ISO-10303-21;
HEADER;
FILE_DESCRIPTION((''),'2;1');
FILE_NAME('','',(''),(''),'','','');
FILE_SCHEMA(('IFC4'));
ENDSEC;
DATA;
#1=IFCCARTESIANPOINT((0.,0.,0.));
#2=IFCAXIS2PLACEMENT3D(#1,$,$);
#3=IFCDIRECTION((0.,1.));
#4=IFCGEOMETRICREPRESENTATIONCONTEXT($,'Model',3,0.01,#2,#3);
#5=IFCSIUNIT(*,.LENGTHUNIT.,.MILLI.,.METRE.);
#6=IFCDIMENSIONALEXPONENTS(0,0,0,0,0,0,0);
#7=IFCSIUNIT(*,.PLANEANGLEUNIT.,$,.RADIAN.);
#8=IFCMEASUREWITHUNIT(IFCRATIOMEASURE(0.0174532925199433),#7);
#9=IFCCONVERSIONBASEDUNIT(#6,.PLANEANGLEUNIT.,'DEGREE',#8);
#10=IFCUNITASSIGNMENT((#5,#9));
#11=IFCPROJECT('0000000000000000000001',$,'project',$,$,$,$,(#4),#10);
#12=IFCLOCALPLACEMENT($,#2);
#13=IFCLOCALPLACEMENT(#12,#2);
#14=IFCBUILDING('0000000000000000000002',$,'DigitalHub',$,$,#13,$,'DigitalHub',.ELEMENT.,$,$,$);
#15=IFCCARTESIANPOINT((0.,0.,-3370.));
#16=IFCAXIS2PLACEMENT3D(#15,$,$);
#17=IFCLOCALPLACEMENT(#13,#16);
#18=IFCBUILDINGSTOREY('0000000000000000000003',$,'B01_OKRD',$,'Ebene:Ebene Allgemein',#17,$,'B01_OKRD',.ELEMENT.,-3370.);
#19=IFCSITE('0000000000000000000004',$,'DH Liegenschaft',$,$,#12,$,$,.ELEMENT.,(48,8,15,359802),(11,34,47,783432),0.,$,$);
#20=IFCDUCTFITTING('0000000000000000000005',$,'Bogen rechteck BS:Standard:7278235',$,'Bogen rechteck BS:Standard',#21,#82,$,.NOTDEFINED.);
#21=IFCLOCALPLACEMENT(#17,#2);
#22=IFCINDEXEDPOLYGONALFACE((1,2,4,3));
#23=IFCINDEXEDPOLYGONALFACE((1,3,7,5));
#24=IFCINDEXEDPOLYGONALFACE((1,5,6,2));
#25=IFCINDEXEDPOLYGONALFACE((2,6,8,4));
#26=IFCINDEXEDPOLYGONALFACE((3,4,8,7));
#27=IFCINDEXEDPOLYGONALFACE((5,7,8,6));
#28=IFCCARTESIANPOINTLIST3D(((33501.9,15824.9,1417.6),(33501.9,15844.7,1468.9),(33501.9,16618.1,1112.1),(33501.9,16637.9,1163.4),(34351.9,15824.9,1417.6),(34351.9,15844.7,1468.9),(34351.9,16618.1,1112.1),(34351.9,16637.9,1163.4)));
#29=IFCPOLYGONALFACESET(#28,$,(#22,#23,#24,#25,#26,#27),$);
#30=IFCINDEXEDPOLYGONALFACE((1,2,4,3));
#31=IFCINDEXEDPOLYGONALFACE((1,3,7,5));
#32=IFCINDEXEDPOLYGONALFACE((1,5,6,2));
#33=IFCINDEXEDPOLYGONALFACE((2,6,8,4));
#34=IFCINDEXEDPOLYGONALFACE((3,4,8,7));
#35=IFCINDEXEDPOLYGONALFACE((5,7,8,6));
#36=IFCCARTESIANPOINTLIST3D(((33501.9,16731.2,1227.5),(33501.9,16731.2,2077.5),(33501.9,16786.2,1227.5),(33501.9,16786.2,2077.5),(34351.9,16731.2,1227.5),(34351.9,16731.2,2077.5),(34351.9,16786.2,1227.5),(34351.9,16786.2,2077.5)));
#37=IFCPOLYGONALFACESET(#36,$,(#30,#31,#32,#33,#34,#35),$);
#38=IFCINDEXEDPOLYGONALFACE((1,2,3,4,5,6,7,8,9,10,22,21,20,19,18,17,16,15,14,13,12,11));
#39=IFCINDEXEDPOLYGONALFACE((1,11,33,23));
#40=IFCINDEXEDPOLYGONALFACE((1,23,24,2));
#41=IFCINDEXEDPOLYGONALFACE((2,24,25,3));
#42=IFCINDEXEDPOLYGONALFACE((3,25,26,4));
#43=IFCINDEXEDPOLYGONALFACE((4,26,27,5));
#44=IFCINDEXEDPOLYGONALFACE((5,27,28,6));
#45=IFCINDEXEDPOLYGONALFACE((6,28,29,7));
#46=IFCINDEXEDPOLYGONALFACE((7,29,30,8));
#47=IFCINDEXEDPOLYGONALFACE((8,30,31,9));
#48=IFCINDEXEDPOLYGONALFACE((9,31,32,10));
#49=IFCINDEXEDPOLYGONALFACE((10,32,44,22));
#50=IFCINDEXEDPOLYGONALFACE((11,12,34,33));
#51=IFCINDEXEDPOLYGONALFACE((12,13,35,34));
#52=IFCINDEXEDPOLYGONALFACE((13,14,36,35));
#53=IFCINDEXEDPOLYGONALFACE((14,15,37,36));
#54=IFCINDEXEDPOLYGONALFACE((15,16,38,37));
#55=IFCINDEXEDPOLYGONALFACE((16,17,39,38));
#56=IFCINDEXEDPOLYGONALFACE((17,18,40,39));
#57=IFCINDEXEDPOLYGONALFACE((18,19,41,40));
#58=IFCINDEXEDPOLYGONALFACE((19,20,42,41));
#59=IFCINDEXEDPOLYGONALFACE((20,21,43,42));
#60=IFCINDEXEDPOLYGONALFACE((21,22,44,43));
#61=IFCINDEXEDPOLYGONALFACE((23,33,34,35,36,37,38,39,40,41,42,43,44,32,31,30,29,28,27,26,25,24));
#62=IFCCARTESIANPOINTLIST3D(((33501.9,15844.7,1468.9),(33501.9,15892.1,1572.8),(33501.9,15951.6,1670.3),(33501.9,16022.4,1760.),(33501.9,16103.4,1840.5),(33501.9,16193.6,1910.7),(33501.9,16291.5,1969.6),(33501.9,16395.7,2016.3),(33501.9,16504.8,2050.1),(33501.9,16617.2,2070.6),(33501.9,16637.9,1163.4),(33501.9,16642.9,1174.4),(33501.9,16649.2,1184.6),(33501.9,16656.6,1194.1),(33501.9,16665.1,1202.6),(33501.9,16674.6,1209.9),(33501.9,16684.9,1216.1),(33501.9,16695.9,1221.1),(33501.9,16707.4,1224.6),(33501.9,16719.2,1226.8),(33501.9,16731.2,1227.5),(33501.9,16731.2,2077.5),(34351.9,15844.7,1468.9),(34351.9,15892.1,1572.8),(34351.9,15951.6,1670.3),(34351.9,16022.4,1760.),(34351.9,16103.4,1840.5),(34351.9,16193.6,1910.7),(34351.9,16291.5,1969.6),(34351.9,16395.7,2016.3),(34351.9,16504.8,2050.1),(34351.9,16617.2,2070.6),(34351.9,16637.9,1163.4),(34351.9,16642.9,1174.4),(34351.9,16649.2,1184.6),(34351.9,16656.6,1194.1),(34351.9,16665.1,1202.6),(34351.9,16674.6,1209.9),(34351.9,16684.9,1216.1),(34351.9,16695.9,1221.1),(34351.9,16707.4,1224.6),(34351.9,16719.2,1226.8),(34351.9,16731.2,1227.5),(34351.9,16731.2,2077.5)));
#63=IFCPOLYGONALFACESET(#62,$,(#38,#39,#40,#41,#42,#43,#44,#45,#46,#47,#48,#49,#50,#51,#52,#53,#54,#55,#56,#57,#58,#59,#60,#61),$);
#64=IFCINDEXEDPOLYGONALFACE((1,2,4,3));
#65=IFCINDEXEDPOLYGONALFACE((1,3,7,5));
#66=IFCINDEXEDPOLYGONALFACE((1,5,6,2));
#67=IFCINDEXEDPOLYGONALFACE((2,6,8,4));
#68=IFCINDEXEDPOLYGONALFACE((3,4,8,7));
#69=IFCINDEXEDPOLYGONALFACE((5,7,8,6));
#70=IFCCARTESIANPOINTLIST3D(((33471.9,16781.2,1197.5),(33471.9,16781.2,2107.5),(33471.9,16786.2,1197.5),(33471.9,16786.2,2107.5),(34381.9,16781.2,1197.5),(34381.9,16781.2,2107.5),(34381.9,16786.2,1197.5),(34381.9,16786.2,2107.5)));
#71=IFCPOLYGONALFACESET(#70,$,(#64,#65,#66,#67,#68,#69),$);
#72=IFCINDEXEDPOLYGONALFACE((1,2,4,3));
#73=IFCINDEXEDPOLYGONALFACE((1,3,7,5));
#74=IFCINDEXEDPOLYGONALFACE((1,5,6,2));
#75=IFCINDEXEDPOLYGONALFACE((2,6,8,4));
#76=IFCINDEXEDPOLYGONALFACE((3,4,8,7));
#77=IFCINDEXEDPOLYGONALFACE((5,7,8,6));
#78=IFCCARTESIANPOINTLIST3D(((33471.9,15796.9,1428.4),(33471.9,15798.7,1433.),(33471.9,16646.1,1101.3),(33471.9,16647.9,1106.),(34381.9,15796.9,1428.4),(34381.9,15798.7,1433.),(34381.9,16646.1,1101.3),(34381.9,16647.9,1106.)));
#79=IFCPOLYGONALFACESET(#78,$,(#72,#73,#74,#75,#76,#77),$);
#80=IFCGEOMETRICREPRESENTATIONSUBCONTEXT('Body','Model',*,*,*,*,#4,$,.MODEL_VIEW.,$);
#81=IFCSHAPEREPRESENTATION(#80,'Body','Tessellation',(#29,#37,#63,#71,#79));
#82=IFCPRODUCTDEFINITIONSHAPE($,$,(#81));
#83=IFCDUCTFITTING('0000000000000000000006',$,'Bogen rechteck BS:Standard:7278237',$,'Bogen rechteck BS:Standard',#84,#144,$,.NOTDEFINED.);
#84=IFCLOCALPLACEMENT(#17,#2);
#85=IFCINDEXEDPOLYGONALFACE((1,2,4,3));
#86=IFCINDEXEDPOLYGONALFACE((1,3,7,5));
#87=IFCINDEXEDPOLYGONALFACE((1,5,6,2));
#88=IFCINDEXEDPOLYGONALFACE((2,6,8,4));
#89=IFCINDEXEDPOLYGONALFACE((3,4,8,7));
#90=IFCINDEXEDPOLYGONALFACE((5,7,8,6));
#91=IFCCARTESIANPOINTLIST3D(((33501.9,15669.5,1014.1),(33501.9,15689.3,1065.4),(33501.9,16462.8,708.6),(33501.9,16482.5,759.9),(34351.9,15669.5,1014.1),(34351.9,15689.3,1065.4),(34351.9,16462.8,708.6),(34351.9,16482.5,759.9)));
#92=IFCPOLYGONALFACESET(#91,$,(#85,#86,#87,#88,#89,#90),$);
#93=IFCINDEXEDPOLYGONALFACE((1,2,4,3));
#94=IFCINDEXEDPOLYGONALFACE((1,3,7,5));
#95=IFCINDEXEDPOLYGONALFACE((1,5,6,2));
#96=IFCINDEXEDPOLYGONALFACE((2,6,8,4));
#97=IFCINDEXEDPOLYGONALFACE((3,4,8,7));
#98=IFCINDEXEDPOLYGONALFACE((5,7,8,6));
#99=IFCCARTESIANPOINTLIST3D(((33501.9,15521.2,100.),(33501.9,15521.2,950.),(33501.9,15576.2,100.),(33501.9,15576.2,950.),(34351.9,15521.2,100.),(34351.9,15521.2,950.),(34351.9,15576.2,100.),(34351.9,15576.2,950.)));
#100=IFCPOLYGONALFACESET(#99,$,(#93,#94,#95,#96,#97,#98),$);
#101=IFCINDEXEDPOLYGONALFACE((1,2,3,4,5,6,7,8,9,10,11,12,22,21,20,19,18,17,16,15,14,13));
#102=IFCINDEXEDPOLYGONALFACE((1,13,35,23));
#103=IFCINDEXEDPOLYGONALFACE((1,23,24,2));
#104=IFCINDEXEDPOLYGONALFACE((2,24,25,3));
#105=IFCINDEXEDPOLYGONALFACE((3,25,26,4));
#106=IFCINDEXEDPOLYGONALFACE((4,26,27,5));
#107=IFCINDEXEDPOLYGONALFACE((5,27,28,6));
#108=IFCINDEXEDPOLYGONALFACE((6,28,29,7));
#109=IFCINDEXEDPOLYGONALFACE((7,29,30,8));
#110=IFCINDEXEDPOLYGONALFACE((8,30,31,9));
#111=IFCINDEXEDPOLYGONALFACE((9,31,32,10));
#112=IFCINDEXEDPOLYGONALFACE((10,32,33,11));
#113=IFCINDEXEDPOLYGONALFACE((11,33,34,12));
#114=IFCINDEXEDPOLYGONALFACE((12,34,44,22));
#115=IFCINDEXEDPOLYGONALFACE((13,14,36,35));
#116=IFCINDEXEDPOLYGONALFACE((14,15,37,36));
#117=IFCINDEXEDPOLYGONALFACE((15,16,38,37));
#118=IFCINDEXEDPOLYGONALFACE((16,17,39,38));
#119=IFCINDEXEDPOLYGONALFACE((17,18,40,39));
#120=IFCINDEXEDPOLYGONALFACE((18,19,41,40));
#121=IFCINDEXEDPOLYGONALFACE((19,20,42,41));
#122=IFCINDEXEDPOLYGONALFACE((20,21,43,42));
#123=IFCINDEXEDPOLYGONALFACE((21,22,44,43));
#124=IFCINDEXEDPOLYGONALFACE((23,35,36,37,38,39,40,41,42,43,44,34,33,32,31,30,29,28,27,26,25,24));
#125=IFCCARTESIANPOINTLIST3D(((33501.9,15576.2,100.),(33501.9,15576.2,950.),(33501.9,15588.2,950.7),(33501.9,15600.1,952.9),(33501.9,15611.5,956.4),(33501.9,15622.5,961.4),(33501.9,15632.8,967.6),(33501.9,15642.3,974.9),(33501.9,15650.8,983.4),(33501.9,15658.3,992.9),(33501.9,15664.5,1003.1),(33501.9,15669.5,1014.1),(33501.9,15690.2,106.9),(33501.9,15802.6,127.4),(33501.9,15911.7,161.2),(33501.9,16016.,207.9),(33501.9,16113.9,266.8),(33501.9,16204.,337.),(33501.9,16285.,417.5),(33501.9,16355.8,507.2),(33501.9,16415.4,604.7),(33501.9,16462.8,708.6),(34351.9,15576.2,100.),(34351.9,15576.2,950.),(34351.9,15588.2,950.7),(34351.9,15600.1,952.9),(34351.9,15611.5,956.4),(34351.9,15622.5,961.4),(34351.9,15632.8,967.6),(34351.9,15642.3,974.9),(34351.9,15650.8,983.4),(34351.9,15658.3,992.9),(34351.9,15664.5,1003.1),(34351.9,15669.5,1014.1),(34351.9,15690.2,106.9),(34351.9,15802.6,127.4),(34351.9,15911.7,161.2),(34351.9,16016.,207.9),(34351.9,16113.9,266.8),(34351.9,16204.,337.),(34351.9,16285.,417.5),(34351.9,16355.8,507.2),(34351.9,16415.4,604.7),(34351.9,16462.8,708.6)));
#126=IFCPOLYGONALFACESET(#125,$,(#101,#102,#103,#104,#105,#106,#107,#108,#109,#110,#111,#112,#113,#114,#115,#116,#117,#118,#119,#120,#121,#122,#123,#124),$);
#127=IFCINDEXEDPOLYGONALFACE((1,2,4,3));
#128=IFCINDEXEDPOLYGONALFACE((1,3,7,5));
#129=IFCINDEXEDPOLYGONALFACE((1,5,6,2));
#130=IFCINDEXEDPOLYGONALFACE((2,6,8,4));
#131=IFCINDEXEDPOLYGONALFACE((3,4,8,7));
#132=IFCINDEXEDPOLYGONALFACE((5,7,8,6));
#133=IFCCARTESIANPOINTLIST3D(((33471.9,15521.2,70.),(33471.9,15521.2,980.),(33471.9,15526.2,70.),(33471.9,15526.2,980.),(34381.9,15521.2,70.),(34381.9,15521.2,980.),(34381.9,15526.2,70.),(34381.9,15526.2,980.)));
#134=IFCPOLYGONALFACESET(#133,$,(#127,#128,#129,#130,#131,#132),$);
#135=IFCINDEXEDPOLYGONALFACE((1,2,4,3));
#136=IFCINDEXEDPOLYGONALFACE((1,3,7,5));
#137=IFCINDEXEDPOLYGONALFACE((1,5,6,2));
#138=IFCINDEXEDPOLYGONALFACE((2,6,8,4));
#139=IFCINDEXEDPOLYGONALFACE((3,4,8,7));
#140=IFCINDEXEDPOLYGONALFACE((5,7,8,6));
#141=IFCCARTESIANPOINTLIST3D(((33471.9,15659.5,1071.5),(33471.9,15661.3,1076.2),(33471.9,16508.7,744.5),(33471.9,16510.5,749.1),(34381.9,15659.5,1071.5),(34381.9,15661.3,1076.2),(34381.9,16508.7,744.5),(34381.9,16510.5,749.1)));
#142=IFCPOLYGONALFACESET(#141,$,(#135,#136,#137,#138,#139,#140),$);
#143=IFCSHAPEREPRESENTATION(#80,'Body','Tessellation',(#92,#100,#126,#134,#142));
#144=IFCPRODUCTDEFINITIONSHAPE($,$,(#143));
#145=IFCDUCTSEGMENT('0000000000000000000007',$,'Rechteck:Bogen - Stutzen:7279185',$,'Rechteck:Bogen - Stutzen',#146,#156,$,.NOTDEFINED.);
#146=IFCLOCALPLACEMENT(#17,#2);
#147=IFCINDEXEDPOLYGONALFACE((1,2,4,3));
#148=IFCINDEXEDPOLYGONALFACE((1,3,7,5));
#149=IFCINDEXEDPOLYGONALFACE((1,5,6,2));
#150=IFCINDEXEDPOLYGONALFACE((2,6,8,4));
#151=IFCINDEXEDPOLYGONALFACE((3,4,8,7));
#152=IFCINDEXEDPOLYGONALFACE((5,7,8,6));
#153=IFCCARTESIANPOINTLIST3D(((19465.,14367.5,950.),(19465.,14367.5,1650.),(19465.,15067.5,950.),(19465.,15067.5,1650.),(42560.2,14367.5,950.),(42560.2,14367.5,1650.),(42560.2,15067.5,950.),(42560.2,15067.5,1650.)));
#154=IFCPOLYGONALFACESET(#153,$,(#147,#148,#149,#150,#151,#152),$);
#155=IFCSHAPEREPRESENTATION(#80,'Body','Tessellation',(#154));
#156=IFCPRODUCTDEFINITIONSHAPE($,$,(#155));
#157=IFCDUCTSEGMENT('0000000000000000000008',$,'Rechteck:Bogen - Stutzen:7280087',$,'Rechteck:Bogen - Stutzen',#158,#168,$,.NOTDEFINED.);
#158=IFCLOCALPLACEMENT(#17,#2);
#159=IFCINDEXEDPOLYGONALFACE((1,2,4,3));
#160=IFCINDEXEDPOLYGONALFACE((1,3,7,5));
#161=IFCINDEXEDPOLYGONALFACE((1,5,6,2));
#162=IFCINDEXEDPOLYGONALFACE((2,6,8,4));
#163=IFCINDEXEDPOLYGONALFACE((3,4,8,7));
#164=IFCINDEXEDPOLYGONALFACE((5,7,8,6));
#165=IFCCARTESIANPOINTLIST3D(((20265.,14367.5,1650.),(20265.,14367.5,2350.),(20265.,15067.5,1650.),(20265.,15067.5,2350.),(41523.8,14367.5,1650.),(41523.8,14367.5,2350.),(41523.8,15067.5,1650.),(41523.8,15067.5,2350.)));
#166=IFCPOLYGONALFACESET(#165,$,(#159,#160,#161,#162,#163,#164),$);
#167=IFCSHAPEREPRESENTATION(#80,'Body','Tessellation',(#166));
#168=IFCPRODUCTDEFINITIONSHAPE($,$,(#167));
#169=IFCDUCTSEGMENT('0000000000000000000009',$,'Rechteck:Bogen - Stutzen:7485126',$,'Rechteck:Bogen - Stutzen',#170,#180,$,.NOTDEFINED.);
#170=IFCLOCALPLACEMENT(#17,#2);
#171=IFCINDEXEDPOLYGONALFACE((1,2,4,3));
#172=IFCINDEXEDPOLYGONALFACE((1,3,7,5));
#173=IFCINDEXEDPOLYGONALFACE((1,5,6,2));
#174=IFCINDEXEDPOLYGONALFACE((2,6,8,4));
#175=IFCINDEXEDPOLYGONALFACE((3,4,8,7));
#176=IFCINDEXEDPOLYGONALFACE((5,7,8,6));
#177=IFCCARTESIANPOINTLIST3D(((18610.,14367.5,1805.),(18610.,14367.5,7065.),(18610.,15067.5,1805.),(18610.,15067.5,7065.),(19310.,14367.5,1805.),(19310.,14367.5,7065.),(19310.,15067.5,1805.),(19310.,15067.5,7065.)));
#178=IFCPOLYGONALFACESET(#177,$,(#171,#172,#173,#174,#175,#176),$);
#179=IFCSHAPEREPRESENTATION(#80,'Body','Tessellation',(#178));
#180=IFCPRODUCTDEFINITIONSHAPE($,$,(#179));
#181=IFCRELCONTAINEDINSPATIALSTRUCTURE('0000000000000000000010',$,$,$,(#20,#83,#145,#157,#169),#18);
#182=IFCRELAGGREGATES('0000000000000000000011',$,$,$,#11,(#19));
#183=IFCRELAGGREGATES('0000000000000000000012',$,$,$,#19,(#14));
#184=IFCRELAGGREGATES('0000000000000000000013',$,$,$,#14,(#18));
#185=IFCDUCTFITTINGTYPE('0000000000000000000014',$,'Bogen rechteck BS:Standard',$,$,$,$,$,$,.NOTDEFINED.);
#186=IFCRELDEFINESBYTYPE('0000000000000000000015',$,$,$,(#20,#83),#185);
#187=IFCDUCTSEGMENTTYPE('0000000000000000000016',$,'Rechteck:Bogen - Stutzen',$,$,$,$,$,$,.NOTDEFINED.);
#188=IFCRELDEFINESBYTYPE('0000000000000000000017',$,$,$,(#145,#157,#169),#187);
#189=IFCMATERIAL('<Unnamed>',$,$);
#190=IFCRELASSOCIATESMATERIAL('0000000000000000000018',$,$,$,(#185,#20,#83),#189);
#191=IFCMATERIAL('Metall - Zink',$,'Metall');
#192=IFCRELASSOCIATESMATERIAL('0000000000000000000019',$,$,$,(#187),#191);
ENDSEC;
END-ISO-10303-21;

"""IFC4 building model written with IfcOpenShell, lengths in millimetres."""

from ifc_helpers import new_model, entity, si_unit, converted_unit, direction, frame, origin, place, context, subcontext, project, spatial, indexed_curve, outline, extrude, source, transform, mapped, material, type_object, type_shapes, element, save


model = new_model("IFC4")

# Units and contexts
model_context = context("Model", 3, precision=0.01, world=origin(), true_north=direction((0.0, 1.0)))
body_context = subcontext(model_context, "Body", "Model", "MODEL_VIEW")
ifc_project = project(units=[si_unit("LENGTHUNIT", "METRE", prefix="MILLI"), converted_unit("PLANEANGLEUNIT", "DEGREE", entity("IfcRatioMeasure", 0.0174532925199433), si_unit("PLANEANGLEUNIT", "RADIAN"), dimensions=[0, 0, 0, 0, 0, 0, 0])], contexts=[model_context])

# Site, building, storey
site_placement = place(None, origin())
site = spatial("IfcSite", under=ifc_project, at=site_placement, Name="DH Liegenschaft", CompositionType="ELEMENT", RefLatitude=(48, 8, 15, 359802), RefLongitude=(11, 34, 47, 783432), RefElevation=0.0)
building_placement = place(site_placement, origin())
building = spatial("IfcBuilding", under=site, at=building_placement, Name="DigitalHub", LongName="DigitalHub", CompositionType="ELEMENT")
storey_placement = place(building_placement, frame((0.0, 0.0, -3370.0)))
storey = spatial("IfcBuildingStorey", under=building, at=storey_placement, Name="B01_OKRD", ObjectType="Ebene:Ebene Allgemein", LongName="B01_OKRD", CompositionType="ELEMENT", Elevation=-3370.0)

# Shared definitions
ifc_material_1 = material(Name="Metall - Zink", Category="Metall")

# Duct fittings
ifc_material_2 = material(Name="<Unnamed>")
duct_fitting_type_1 = type_object("IfcDuctFittingType", Name="Bogen rechteck BS:Standard", PredefinedType="NOTDEFINED", material=ifc_material_2)
shared_shape_1 = source(origin(), body_context, "Body", "SweptSolid", [
    extrude(outline(indexed_curve([(-27.5, -425.0), (27.5, -425.0), (27.5, 425.0), (-27.5, 425.0), (-27.5, -425.0)], self_intersect=False)), frame((139.4, 362.0, -425.0), z_axis=(0.0, 0.0, 1.0), x_axis=(0.359372, 0.933194, 0.0)), (0.0, 0.0, 1.0), 850.0),
    extrude(outline(indexed_curve([(-425.0, -27.5), (425.0, -27.5), (425.0, 27.5), (-425.0, 27.5), (-425.0, -27.5)], self_intersect=False)), frame((-387.9, 0.0, -425.0), z_axis=(0.0, 0.0, 1.0), x_axis=(0.0, -1.0, 0.0)), (0.0, 0.0, 1.0), 850.0),
    extrude(outline(indexed_curve([(-593.2, -245.0), (256.8, -245.0), (257.6, -233.0), (259.7, -221.1), (263.3, -209.6), (268.2, -198.7), (274.4, -188.4), (281.8, -178.9), (290.3, -170.3), (299.7, -162.9), (310.0, -156.6), (320.9, -151.6), (15.4, 641.6), (-88.5, 594.2), (-186.0, 534.7), (-275.7, 463.9), (-356.2, 382.8), (-426.4, 292.7), (-485.2, 194.8), (-531.9, 90.6), (-565.8, -18.6), (-586.3, -130.9), (-593.2, -245.0)], self_intersect=False)), frame((-115.4, 168.2, -425.0), z_axis=(0.0, 0.0, 1.0), x_axis=(-0.933194, 0.359372, 0.0)), (0.0, 0.0, 1.0), 850.0),
    extrude(outline(indexed_curve([(-2.5, -455.0), (2.5, -455.0), (2.5, 455.0), (-2.5, 455.0), (-2.5, -455.0)], self_intersect=False)), frame((-412.9, 0.0, -455.0)), (0.0, 0.0, 1.0), 910.0),
    extrude(outline(indexed_curve([(-2.5, -455.0), (2.5, -455.0), (2.5, 455.0), (-2.5, 455.0), (-2.5, -455.0)], self_intersect=False)), frame((148.4, 385.3, -455.0), z_axis=(0.0, 0.0, 1.0), x_axis=(0.359372, 0.933194, 0.0)), (0.0, 0.0, 1.0), 910.0),
])
type_shapes(duct_fitting_type_1, [shared_shape_1])
for number, where, z_axis, x_axis, name in (
    (1, (33926.9, 16370.8, 1652.5), (1.0, 0.0, 0.0), (0.0, -1.0, 0.0), "Bogen rechteck BS:Standard:7278235"),
    (2, (33926.9, 15936.6, 525.0), (1.0, 0.0, 0.0), (0.0, 1.0, 0.0), "Bogen rechteck BS:Standard:7278237"),
):
    element("IfcDuctFitting", number, at=place(storey_placement, frame(where, z_axis=z_axis, x_axis=x_axis)), inside=storey, type_object=duct_fitting_type_1, material=ifc_material_2, Name=name, ObjectType="Bogen rechteck BS:Standard", PredefinedType="NOTDEFINED", context=body_context, shape_type="MappedRepresentation", body=[
        mapped(shared_shape_1, transform((0.0, 0.0, 0.0), scale=1.0)),
    ])

# Duct segments
duct_segment_type_1 = type_object("IfcDuctSegmentType", Name="Rechteck:Bogen - Stutzen", PredefinedType="NOTDEFINED", material=ifc_material_1)
duct_segment_1_placement = place(storey_placement, frame((19465.0, 14367.5, 950.0)))
element("IfcDuctSegment", 3, at=duct_segment_1_placement, inside=storey, type_object=duct_segment_type_1, Name="Rechteck:Bogen - Stutzen:7279185", ObjectType="Rechteck:Bogen - Stutzen", PredefinedType="NOTDEFINED", context=body_context, shape_type="SweptSolid", body=[
    extrude(outline(indexed_curve([(-11547.6, -350.0), (11547.6, -350.0), (11547.6, 350.0), (-11547.6, 350.0), (-11547.6, -350.0)], self_intersect=False)), frame((11547.6, 350.0, 0.0)), (0.0, 0.0, 1.0), 700.0),
])
duct_segment_2_placement = place(storey_placement, frame((20265.0, 14367.5, 1650.0)))
element("IfcDuctSegment", 4, at=duct_segment_2_placement, inside=storey, type_object=duct_segment_type_1, Name="Rechteck:Bogen - Stutzen:7280087", ObjectType="Rechteck:Bogen - Stutzen", PredefinedType="NOTDEFINED", context=body_context, shape_type="SweptSolid", body=[
    extrude(outline(indexed_curve([(-10629.4, -350.0), (10629.4, -350.0), (10629.4, 350.0), (-10629.4, 350.0), (-10629.4, -350.0)], self_intersect=False)), frame((10629.4, 350.0, 0.0), z_axis=(0.0, 0.0, 1.0), x_axis=(-1.0, 0.0, 0.0)), (0.0, 0.0, 1.0), 700.0),
])
duct_segment_3_placement = place(storey_placement, frame((18610.0, 14367.5, 1805.0)))
element("IfcDuctSegment", 5, at=duct_segment_3_placement, inside=storey, type_object=duct_segment_type_1, Name="Rechteck:Bogen - Stutzen:7485126", ObjectType="Rechteck:Bogen - Stutzen", PredefinedType="NOTDEFINED", context=body_context, shape_type="SweptSolid", body=[
    extrude(outline(indexed_curve([(-350.0, -350.0), (350.0, -350.0), (350.0, 350.0), (-350.0, 350.0), (-350.0, -350.0)], self_intersect=False)), frame((350.0, 350.0, 0.0)), (0.0, 0.0, 1.0), 5260.0),
])

save(model, "model.ifc")
